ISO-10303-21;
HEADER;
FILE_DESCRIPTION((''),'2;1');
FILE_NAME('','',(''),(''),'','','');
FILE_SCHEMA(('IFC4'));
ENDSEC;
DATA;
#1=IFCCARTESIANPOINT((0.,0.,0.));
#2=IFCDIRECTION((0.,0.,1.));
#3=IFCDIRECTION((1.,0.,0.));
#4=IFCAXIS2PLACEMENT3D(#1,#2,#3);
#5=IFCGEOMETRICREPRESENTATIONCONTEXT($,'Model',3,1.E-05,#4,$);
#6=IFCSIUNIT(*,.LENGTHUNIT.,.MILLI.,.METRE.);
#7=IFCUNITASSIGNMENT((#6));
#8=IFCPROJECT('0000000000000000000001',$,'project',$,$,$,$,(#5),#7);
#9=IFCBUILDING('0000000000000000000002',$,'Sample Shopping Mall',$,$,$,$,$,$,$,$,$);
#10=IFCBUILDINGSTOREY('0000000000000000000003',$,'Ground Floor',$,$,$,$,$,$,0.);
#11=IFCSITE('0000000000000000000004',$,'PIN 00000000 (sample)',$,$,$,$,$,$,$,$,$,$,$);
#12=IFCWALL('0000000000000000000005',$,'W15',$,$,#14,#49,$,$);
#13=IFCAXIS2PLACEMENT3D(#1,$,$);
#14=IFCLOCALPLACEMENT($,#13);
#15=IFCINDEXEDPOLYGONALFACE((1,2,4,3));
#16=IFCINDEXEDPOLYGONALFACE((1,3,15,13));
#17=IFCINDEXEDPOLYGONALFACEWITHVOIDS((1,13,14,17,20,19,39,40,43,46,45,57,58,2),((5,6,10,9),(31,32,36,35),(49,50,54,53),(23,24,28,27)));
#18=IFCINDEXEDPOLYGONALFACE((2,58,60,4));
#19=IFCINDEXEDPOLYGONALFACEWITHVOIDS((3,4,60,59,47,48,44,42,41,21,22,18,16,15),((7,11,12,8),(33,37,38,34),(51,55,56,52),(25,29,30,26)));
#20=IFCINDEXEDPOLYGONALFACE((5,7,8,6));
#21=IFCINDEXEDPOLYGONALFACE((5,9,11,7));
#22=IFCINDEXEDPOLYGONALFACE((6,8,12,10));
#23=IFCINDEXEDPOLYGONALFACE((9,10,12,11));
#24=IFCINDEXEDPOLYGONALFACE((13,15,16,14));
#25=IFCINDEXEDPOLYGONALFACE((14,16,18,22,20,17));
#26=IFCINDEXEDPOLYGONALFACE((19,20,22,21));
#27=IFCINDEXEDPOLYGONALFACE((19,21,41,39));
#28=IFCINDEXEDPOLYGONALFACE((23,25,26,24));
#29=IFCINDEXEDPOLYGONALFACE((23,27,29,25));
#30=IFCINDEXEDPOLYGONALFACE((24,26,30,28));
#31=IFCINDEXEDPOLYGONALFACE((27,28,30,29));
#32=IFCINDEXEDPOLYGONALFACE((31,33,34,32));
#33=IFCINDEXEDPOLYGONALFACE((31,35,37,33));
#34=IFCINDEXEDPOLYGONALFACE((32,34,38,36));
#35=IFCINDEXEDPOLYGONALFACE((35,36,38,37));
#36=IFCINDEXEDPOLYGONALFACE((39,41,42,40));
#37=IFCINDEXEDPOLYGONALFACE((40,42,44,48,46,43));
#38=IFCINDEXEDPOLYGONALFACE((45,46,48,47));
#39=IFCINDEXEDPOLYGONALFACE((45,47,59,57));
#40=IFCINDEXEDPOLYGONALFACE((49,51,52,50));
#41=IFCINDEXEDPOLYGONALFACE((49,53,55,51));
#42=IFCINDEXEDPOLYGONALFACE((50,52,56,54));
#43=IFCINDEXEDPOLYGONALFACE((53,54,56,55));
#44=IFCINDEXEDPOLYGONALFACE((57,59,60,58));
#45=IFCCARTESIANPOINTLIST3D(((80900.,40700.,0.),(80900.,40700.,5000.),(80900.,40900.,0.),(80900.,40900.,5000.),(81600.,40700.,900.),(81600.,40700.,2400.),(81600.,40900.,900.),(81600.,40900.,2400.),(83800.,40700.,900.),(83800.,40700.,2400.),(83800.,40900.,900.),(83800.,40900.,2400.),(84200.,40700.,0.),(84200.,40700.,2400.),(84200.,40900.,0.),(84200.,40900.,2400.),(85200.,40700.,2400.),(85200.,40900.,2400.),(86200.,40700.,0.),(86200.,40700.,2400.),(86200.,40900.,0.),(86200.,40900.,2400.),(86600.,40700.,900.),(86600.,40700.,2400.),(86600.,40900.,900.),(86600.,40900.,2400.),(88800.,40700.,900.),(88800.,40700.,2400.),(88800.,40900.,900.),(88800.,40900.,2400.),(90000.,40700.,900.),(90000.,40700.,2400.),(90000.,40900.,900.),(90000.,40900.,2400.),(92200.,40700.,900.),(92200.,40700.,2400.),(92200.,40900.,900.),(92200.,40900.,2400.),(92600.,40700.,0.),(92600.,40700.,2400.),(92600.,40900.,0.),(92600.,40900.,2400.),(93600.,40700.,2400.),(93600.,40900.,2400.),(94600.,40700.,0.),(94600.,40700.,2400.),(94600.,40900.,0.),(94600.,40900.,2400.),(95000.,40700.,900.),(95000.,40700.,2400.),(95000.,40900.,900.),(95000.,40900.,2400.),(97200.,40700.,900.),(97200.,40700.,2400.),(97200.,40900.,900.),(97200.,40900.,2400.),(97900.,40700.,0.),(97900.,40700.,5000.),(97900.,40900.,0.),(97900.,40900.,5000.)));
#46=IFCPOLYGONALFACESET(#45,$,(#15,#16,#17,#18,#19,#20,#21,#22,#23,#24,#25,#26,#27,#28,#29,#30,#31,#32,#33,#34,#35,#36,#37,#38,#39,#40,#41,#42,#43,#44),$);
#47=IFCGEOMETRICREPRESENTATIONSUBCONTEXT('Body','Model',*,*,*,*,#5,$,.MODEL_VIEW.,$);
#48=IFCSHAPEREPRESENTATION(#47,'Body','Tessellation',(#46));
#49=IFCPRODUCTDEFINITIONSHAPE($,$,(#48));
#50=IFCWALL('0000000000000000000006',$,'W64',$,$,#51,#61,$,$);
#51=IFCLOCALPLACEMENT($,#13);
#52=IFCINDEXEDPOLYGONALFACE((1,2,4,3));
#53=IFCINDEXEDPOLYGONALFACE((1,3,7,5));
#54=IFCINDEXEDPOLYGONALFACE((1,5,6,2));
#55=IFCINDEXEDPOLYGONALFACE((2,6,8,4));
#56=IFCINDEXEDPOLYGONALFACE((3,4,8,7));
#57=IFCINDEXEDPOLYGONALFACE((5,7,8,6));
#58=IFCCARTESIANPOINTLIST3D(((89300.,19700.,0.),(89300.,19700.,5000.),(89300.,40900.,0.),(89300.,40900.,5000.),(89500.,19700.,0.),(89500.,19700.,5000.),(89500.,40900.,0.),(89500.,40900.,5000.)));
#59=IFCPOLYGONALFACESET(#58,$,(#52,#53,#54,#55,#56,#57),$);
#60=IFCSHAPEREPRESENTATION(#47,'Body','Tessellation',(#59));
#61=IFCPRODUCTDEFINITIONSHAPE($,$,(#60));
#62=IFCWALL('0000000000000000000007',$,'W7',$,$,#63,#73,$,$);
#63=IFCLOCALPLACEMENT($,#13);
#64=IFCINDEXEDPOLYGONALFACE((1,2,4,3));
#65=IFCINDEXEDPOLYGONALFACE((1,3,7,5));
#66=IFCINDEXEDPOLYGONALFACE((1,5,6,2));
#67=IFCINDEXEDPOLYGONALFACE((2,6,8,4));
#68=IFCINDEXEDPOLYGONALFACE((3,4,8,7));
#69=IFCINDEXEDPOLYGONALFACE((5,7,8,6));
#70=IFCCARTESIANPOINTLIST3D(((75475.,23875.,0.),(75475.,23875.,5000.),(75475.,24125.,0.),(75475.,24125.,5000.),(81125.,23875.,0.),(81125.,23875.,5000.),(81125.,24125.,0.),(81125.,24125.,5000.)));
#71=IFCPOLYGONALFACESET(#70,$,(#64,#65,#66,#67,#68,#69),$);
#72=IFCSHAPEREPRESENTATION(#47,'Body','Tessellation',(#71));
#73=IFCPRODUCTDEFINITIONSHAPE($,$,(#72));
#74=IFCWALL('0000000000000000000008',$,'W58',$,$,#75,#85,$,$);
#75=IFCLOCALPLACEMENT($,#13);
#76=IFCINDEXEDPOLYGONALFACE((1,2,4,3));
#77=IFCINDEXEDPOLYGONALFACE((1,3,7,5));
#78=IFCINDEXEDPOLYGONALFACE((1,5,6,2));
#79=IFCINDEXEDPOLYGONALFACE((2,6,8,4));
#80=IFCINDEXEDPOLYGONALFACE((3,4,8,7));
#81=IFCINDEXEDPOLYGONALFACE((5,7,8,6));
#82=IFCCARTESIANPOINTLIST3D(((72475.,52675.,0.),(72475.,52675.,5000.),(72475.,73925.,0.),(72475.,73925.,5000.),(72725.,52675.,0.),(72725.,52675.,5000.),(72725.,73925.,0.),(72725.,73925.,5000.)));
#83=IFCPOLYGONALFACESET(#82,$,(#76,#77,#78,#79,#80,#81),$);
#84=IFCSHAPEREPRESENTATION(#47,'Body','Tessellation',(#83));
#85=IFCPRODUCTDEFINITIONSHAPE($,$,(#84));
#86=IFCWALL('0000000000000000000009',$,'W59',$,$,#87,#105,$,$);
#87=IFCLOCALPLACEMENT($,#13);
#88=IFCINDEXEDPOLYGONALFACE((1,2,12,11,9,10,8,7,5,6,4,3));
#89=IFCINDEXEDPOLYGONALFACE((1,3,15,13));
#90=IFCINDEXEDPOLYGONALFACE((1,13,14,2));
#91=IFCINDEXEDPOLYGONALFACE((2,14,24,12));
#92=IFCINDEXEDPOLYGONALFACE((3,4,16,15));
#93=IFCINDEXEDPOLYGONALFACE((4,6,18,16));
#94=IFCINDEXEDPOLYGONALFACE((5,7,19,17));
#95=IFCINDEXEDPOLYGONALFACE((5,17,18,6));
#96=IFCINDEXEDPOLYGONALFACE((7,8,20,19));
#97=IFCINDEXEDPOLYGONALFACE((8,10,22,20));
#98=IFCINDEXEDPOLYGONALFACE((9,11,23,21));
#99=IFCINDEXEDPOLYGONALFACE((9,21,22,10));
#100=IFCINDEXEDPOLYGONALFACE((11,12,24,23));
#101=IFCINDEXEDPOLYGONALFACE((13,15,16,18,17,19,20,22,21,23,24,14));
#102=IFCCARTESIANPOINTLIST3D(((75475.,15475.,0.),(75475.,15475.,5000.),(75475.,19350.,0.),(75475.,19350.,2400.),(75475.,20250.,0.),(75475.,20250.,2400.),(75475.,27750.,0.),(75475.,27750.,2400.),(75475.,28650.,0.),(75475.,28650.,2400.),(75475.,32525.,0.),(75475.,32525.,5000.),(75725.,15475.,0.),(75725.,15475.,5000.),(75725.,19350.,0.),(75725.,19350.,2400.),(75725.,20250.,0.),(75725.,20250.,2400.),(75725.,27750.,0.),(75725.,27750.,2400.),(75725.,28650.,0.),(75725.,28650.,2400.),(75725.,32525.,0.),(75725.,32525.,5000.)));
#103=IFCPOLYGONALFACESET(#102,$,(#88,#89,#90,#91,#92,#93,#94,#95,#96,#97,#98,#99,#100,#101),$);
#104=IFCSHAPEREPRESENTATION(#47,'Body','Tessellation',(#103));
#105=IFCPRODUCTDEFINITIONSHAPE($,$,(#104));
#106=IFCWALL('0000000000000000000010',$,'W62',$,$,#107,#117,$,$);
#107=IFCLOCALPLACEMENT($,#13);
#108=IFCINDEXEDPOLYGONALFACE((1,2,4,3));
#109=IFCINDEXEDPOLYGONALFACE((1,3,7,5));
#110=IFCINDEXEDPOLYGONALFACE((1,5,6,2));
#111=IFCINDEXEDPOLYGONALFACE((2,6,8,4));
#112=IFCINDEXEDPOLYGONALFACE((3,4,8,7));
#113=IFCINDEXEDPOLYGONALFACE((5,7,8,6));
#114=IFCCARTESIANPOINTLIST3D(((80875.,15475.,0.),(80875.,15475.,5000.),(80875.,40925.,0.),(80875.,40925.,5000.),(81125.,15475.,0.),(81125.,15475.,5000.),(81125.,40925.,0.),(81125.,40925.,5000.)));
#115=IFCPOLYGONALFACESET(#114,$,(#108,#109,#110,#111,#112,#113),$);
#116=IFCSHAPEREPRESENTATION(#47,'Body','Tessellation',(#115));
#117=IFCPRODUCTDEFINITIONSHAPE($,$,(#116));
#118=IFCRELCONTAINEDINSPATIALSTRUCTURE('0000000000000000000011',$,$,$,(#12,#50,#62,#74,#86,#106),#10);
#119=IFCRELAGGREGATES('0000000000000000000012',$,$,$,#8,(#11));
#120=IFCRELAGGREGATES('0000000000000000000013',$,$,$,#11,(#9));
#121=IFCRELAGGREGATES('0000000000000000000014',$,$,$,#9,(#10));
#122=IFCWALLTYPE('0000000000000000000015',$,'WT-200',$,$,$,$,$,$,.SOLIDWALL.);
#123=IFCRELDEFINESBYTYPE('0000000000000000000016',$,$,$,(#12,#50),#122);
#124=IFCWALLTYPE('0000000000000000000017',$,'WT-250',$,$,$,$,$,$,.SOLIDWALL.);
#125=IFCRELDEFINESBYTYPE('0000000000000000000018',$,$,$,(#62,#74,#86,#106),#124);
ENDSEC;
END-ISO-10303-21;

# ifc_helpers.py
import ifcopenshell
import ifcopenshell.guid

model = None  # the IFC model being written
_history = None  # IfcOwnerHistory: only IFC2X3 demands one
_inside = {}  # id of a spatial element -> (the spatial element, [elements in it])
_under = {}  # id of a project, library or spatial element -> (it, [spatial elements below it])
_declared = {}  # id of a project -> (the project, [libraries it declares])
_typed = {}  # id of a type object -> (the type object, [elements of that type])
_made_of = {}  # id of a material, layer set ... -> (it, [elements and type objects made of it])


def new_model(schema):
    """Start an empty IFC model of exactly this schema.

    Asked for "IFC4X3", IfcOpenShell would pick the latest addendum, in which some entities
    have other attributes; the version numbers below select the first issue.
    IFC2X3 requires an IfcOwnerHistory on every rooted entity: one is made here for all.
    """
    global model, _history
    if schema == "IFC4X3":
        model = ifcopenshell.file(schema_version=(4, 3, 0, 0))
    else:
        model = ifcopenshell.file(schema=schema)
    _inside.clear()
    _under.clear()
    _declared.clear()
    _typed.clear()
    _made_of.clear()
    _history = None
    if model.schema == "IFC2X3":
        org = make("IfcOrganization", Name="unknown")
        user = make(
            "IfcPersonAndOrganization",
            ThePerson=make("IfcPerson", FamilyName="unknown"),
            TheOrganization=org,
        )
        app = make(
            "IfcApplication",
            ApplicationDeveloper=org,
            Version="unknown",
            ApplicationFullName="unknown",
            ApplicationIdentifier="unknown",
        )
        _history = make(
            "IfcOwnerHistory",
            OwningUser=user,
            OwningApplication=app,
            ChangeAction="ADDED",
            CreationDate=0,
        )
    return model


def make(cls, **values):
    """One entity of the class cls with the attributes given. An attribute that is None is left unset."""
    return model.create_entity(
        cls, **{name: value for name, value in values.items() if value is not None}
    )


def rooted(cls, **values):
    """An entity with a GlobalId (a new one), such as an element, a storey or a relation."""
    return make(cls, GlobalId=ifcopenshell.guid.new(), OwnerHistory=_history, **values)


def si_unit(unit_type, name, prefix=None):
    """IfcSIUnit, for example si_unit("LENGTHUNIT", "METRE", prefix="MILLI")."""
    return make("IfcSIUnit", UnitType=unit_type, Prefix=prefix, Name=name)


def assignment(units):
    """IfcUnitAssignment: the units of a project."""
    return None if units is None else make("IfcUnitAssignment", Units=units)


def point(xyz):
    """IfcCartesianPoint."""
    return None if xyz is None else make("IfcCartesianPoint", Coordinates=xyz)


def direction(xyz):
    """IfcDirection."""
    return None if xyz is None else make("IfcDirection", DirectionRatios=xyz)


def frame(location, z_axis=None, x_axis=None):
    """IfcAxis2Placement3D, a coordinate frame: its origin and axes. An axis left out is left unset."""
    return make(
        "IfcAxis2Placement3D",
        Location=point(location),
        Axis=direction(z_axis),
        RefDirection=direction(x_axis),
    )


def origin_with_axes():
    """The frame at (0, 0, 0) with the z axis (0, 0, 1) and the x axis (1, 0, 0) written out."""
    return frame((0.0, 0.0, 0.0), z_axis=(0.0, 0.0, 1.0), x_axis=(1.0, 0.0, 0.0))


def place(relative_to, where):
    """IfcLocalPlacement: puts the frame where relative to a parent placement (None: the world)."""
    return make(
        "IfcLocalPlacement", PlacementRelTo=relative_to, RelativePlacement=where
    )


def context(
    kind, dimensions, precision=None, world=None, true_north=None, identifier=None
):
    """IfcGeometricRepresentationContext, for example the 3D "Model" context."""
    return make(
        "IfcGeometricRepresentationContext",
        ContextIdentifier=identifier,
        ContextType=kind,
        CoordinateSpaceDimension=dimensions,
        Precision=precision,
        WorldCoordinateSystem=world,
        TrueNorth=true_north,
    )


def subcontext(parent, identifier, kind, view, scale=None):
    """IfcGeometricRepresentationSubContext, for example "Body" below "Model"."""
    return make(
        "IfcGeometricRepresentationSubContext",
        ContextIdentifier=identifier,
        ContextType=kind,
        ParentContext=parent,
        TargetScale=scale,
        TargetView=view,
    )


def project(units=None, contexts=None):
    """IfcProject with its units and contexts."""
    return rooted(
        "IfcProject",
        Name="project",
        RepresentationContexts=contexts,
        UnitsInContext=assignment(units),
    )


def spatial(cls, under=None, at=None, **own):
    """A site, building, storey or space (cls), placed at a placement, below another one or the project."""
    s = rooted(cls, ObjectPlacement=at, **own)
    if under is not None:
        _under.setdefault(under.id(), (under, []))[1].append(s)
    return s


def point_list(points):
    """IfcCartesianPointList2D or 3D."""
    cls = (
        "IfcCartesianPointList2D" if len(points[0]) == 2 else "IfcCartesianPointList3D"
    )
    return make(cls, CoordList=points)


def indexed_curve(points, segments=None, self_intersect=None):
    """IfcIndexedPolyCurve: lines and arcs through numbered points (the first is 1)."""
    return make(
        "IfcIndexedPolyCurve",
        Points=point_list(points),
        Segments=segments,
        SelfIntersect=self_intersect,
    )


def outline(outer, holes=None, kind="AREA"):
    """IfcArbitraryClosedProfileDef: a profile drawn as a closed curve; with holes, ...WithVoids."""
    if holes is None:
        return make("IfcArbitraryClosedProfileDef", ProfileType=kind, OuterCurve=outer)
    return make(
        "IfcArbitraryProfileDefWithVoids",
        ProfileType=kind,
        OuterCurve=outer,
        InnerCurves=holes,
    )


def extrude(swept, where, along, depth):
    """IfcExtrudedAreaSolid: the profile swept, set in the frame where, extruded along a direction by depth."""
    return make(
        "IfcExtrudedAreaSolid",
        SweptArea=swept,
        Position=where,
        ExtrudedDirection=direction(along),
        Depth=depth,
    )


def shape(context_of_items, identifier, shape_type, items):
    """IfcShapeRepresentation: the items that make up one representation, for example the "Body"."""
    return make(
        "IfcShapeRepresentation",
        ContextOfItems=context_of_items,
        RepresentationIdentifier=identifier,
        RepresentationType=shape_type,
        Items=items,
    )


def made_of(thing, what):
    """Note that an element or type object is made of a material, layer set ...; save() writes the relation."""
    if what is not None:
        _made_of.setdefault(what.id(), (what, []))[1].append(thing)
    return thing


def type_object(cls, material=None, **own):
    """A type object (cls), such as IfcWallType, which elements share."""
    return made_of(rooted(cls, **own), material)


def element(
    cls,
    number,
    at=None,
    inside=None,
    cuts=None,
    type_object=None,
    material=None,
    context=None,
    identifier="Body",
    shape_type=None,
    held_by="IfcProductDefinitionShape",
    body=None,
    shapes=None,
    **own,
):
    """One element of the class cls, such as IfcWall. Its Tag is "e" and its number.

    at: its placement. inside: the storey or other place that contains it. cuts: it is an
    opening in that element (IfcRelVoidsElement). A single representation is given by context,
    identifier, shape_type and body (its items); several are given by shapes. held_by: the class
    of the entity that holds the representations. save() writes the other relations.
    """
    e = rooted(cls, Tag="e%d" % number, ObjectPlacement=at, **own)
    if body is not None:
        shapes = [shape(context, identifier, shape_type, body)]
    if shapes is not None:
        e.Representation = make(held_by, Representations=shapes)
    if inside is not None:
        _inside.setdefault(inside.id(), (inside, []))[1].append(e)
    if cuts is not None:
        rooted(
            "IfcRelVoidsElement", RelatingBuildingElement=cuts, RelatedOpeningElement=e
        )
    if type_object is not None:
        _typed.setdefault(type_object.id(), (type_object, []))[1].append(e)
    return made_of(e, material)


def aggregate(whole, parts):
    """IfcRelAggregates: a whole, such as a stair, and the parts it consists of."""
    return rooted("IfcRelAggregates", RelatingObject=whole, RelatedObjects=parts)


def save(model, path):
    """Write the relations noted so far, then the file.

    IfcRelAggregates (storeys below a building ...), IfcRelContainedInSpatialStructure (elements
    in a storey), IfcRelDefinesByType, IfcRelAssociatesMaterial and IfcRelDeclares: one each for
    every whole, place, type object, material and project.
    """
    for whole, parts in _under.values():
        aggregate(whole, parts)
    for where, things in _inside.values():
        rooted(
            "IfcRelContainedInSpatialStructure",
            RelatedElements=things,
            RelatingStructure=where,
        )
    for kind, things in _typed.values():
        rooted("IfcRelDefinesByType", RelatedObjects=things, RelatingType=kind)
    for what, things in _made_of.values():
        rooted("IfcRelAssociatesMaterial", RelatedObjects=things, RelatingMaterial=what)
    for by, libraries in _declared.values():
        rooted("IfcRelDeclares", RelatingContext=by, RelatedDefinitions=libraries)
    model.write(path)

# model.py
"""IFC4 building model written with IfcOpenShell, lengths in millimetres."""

from ifc_helpers import new_model, si_unit, frame, origin_with_axes, place, context, subcontext, project, spatial, indexed_curve, outline, extrude, type_object, element, save


model = new_model("IFC4")

# Units and contexts
model_context = context("Model", 3, precision=1e-05, world=origin_with_axes())
body_context = subcontext(model_context, "Body", "Model", "MODEL_VIEW")
ifc_project = project(units=[si_unit("LENGTHUNIT", "METRE", prefix="MILLI")], contexts=[model_context])

# Site, building, storey
site = spatial("IfcSite", under=ifc_project, Name="PIN 00000000 (sample)")
building = spatial("IfcBuilding", under=site, Name="Sample Shopping Mall")
storey = spatial("IfcBuildingStorey", under=building, Name="Ground Floor", Elevation=0.0)

# Wall, openings
wall_type_1 = type_object("IfcWallType", Name="WT-200", PredefinedType="SOLIDWALL")
wall_1_placement = place(None, frame((80900.0, 40700.0, 0.0), z_axis=(0.0, 0.0, 1.0), x_axis=(1.0, 0.0, 0.0)))
wall_1 = element("IfcWall", 1, at=wall_1_placement, inside=storey, type_object=wall_type_1, Name="W15", context=body_context, shape_type="SweptSolid", body=[
    extrude(outline(indexed_curve([(0.0, 0.0), (0.0, 200.0), (17000.0, 200.0), (17000.0, 0.0), (0.0, 0.0)], self_intersect=False)), origin_with_axes(), (0.0, 0.0, 1.0), 5000.0),
])
opening_1_placement = place(wall_1_placement, frame((3300.0, -100.0, 0.0), z_axis=(0.0, 0.0, 1.0), x_axis=(1.0, 0.0, 0.0)))
element("IfcOpeningElement", 2, at=opening_1_placement, cuts=wall_1, context=body_context, shape_type="SweptSolid", body=[
    extrude(outline(indexed_curve([(0.0, 0.0), (0.0, 400.0), (1000.0, 400.0), (1000.0, 0.0), (0.0, 0.0)], self_intersect=False)), origin_with_axes(), (0.0, 0.0, 1.0), 2400.0),
])
opening_2_placement = place(wall_1_placement, frame((4300.0, -100.0, 0.0), z_axis=(0.0, 0.0, 1.0), x_axis=(1.0, 0.0, 0.0)))
element("IfcOpeningElement", 3, at=opening_2_placement, cuts=wall_1, context=body_context, shape_type="SweptSolid", body=[
    extrude(outline(indexed_curve([(0.0, 0.0), (0.0, 400.0), (1000.0, 400.0), (1000.0, 0.0), (0.0, 0.0)], self_intersect=False)), origin_with_axes(), (0.0, 0.0, 1.0), 2400.0),
])
opening_3_placement = place(wall_1_placement, frame((11700.0, -100.0, 0.0), z_axis=(0.0, 0.0, 1.0), x_axis=(1.0, 0.0, 0.0)))
element("IfcOpeningElement", 4, at=opening_3_placement, cuts=wall_1, context=body_context, shape_type="SweptSolid", body=[
    extrude(outline(indexed_curve([(0.0, 0.0), (0.0, 400.0), (1000.0, 400.0), (1000.0, 0.0), (0.0, 0.0)], self_intersect=False)), origin_with_axes(), (0.0, 0.0, 1.0), 2400.0),
])
opening_4_placement = place(wall_1_placement, frame((12700.0, -100.0, 0.0), z_axis=(0.0, 0.0, 1.0), x_axis=(1.0, 0.0, 0.0)))
element("IfcOpeningElement", 5, at=opening_4_placement, cuts=wall_1, context=body_context, shape_type="SweptSolid", body=[
    extrude(outline(indexed_curve([(0.0, 0.0), (0.0, 400.0), (1000.0, 400.0), (1000.0, 0.0), (0.0, 0.0)], self_intersect=False)), origin_with_axes(), (0.0, 0.0, 1.0), 2400.0),
])
opening_5_placement = place(wall_1_placement, frame((700.0, -100.0, 900.0), z_axis=(0.0, 0.0, 1.0), x_axis=(1.0, 0.0, 0.0)))
element("IfcOpeningElement", 6, at=opening_5_placement, cuts=wall_1, context=body_context, shape_type="SweptSolid", body=[
    extrude(outline(indexed_curve([(0.0, 0.0), (0.0, 400.0), (2200.0, 400.0), (2200.0, 0.0), (0.0, 0.0)], self_intersect=False)), origin_with_axes(), (0.0, 0.0, 1.0), 1500.0),
])
opening_6_placement = place(wall_1_placement, frame((5700.0, -100.0, 900.0), z_axis=(0.0, 0.0, 1.0), x_axis=(1.0, 0.0, 0.0)))
element("IfcOpeningElement", 7, at=opening_6_placement, cuts=wall_1, context=body_context, shape_type="SweptSolid", body=[
    extrude(outline(indexed_curve([(0.0, 0.0), (0.0, 400.0), (2200.0, 400.0), (2200.0, 0.0), (0.0, 0.0)], self_intersect=False)), origin_with_axes(), (0.0, 0.0, 1.0), 1500.0),
])
opening_7_placement = place(wall_1_placement, frame((9100.0, -100.0, 900.0), z_axis=(0.0, 0.0, 1.0), x_axis=(1.0, 0.0, 0.0)))
element("IfcOpeningElement", 8, at=opening_7_placement, cuts=wall_1, context=body_context, shape_type="SweptSolid", body=[
    extrude(outline(indexed_curve([(0.0, 0.0), (0.0, 400.0), (2200.0, 400.0), (2200.0, 0.0), (0.0, 0.0)], self_intersect=False)), origin_with_axes(), (0.0, 0.0, 1.0), 1500.0),
])
opening_8_placement = place(wall_1_placement, frame((14100.0, -100.0, 900.0), z_axis=(0.0, 0.0, 1.0), x_axis=(1.0, 0.0, 0.0)))
element("IfcOpeningElement", 9, at=opening_8_placement, cuts=wall_1, context=body_context, shape_type="SweptSolid", body=[
    extrude(outline(indexed_curve([(0.0, 0.0), (0.0, 400.0), (2200.0, 400.0), (2200.0, 0.0), (0.0, 0.0)], self_intersect=False)), origin_with_axes(), (0.0, 0.0, 1.0), 1500.0),
])

# Walls
wall_2_placement = place(None, frame((89500.0, 19700.0, 0.0), z_axis=(0.0, 0.0, 1.0), x_axis=(0.0, 1.0, 0.0)))
element("IfcWall", 10, at=wall_2_placement, inside=storey, type_object=wall_type_1, Name="W64", context=body_context, shape_type="SweptSolid", body=[
    extrude(outline(indexed_curve([(0.0, 0.0), (0.0, 200.0), (21200.0, 200.0), (21200.0, 0.0), (0.0, 0.0)], self_intersect=False)), origin_with_axes(), (0.0, 0.0, 1.0), 5000.0),
])
wall_type_2 = type_object("IfcWallType", Name="WT-250", PredefinedType="SOLIDWALL")
wall_3_placement = place(None, frame((75475.0, 23875.0, 0.0), z_axis=(0.0, 0.0, 1.0), x_axis=(1.0, 0.0, 0.0)))
element("IfcWall", 11, at=wall_3_placement, inside=storey, type_object=wall_type_2, Name="W7", context=body_context, shape_type="SweptSolid", body=[
    extrude(outline(indexed_curve([(0.0, 0.0), (0.0, 250.0), (5650.0, 250.0), (5650.0, 0.0), (0.0, 0.0)], self_intersect=False)), origin_with_axes(), (0.0, 0.0, 1.0), 5000.0),
])
wall_4_placement = place(None, frame((72725.0, 52675.0, 0.0), z_axis=(0.0, 0.0, 1.0), x_axis=(0.0, 1.0, 0.0)))
element("IfcWall", 12, at=wall_4_placement, inside=storey, type_object=wall_type_2, Name="W58", context=body_context, shape_type="SweptSolid", body=[
    extrude(outline(indexed_curve([(0.0, 0.0), (0.0, 250.0), (21250.0, 250.0), (21250.0, 0.0), (0.0, 0.0)], self_intersect=False)), origin_with_axes(), (0.0, 0.0, 1.0), 5000.0),
])

# Wall, openings
wall_5_placement = place(None, frame((75725.0, 15475.0, 0.0), z_axis=(0.0, 0.0, 1.0), x_axis=(0.0, 1.0, 0.0)))
wall_5 = element("IfcWall", 13, at=wall_5_placement, inside=storey, type_object=wall_type_2, Name="W59", context=body_context, shape_type="SweptSolid", body=[
    extrude(outline(indexed_curve([(0.0, 0.0), (0.0, 250.0), (17050.0, 250.0), (17050.0, 0.0), (0.0, 0.0)], self_intersect=False)), origin_with_axes(), (0.0, 0.0, 1.0), 5000.0),
])
opening_9_placement = place(wall_5_placement, frame((12275.0, -100.0, 0.0), z_axis=(0.0, 0.0, 1.0), x_axis=(1.0, 0.0, 0.0)))
element("IfcOpeningElement", 14, at=opening_9_placement, cuts=wall_5, context=body_context, shape_type="SweptSolid", body=[
    extrude(outline(indexed_curve([(0.0, 0.0), (0.0, 450.0), (900.0, 450.0), (900.0, 0.0), (0.0, 0.0)], self_intersect=False)), origin_with_axes(), (0.0, 0.0, 1.0), 2400.0),
])
opening_10_placement = place(wall_5_placement, frame((3875.0, -100.0, 0.0), z_axis=(0.0, 0.0, 1.0), x_axis=(1.0, 0.0, 0.0)))
element("IfcOpeningElement", 15, at=opening_10_placement, cuts=wall_5, context=body_context, shape_type="SweptSolid", body=[
    extrude(outline(indexed_curve([(0.0, 0.0), (0.0, 450.0), (900.0, 450.0), (900.0, 0.0), (0.0, 0.0)], self_intersect=False)), origin_with_axes(), (0.0, 0.0, 1.0), 2400.0),
])

# Wall
wall_6_placement = place(None, frame((81125.0, 15475.0, 0.0), z_axis=(0.0, 0.0, 1.0), x_axis=(0.0, 1.0, 0.0)))
element("IfcWall", 16, at=wall_6_placement, inside=storey, type_object=wall_type_2, Name="W62", context=body_context, shape_type="SweptSolid", body=[
    extrude(outline(indexed_curve([(0.0, 0.0), (0.0, 250.0), (25450.0, 250.0), (25450.0, 0.0), (0.0, 0.0)], self_intersect=False)), origin_with_axes(), (0.0, 0.0, 1.0), 5000.0),
])

save(model, "model.ifc")
